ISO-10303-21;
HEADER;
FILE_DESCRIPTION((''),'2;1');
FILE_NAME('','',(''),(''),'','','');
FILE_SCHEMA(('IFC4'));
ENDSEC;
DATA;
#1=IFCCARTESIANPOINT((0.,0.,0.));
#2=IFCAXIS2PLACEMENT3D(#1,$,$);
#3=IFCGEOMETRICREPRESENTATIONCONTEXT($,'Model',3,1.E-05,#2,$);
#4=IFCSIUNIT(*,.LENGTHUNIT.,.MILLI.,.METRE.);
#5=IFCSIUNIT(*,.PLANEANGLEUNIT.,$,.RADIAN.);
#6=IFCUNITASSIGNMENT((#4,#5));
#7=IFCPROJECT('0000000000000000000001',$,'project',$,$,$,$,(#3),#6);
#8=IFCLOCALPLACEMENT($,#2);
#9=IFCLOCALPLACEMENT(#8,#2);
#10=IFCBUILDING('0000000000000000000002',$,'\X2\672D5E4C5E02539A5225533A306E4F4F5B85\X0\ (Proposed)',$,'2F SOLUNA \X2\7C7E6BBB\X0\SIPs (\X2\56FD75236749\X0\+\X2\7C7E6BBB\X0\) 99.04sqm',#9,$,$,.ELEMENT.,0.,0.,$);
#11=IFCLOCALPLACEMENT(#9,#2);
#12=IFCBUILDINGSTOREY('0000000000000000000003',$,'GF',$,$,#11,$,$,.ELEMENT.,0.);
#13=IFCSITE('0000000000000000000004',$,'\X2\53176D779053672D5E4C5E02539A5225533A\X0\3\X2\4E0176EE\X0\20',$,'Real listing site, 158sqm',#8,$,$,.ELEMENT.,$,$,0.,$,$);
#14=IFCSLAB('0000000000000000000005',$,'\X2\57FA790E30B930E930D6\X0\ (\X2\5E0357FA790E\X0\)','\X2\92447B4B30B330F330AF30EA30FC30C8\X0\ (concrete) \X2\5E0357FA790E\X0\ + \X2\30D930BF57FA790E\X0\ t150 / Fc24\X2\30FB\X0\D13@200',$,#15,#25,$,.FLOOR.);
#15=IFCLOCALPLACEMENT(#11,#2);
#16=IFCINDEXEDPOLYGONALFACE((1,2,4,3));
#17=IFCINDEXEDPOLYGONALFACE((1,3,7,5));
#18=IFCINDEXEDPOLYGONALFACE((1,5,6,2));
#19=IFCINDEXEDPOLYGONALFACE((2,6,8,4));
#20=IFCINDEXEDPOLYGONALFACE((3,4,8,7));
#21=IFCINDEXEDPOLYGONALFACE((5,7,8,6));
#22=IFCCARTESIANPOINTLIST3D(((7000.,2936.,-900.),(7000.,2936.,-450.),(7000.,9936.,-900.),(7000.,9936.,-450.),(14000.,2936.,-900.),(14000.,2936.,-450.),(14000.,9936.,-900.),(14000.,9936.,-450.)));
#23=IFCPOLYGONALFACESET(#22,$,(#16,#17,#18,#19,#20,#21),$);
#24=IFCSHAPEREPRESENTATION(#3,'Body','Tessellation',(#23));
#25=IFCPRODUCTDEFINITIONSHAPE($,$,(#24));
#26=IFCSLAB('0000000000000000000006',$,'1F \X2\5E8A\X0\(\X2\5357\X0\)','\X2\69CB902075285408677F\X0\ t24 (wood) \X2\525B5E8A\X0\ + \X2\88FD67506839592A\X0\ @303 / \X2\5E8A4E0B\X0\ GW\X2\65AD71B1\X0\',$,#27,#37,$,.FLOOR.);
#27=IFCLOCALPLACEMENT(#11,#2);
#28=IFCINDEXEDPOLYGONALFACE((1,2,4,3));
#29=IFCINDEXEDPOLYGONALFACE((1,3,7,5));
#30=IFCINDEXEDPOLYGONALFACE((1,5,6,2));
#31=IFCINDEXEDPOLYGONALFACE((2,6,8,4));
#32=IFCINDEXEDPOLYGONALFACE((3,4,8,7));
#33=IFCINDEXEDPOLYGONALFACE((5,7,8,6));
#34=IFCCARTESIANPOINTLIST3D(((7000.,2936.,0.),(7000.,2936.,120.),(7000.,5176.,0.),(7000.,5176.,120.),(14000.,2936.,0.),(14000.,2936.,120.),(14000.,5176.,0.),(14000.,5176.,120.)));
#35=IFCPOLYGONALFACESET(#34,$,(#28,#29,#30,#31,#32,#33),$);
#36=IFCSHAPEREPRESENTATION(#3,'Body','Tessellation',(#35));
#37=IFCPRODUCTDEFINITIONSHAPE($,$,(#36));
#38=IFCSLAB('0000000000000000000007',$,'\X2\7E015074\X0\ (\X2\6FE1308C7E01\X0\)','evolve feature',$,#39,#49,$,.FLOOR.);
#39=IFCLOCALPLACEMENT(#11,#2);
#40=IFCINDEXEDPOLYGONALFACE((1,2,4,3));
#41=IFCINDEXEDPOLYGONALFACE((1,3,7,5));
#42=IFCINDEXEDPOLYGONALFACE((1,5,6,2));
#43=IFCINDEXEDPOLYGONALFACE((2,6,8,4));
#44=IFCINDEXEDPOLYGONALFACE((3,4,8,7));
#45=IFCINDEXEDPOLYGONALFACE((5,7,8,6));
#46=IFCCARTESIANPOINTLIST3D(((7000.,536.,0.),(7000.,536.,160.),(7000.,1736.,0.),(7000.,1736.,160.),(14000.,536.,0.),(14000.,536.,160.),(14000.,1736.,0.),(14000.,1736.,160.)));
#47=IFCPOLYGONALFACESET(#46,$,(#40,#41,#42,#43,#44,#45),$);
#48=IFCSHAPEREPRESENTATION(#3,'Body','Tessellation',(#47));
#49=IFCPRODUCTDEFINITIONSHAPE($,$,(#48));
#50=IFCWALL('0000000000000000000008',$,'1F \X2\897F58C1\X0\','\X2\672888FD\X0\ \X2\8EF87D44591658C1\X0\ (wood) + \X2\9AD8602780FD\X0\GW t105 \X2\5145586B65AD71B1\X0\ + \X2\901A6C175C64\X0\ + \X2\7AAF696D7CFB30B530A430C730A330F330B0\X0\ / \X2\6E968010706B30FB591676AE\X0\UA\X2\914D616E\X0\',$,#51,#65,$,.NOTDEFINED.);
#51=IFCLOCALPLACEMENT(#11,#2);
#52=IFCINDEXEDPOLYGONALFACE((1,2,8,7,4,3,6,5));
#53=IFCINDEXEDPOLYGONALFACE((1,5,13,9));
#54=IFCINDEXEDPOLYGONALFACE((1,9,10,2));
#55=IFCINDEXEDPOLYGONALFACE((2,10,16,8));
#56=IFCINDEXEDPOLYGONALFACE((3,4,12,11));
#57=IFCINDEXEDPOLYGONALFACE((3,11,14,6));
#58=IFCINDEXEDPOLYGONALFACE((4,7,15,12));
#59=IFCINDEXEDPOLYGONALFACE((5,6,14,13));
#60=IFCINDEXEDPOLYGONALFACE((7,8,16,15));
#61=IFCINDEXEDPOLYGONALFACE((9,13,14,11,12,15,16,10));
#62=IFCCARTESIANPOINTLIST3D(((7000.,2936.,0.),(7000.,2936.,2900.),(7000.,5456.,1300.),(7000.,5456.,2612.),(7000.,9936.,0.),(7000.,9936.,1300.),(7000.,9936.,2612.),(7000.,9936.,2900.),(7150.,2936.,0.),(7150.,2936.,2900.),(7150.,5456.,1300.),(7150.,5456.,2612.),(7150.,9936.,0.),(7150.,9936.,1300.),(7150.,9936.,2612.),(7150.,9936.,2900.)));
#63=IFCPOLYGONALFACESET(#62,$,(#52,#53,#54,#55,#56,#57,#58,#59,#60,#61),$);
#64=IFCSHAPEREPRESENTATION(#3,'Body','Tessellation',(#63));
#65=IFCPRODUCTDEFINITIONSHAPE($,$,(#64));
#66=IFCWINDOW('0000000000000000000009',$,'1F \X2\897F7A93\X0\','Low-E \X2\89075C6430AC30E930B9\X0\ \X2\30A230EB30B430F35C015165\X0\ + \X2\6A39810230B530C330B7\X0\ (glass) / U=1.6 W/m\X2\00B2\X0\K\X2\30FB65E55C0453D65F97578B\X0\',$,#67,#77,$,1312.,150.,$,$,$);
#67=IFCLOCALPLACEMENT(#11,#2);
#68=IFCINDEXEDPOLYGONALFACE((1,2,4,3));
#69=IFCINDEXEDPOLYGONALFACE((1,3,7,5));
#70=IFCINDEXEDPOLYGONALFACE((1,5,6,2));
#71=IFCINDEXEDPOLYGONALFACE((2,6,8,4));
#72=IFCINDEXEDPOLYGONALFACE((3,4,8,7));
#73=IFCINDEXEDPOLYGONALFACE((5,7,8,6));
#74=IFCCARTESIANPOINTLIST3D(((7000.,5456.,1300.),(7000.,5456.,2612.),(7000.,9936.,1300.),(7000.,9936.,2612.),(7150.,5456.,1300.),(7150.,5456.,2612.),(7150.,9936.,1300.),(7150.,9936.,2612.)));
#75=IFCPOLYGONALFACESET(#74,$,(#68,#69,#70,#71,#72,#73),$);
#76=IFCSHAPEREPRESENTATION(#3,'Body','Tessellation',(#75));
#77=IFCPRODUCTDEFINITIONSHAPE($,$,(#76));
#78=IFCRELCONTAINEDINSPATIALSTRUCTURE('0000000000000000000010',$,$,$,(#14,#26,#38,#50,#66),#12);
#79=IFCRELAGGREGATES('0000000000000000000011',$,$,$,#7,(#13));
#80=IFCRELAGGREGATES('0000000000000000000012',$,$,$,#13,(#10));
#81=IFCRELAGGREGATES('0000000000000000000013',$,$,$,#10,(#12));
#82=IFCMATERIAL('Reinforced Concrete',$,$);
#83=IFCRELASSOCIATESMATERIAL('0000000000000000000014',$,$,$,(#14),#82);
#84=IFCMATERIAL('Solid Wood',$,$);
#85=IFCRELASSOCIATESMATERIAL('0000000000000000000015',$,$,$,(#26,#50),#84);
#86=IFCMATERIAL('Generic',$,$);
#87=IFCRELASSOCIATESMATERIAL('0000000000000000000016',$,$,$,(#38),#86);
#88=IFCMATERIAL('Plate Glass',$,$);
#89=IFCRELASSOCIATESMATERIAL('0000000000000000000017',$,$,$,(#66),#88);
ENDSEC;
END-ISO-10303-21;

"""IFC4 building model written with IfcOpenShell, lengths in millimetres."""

from ifc_helpers import new_model, si_unit, frame, frame_2d, origin, place, context, project, spatial, rectangle, extrude, material, element, fill, save


model = new_model("IFC4")

# Units and contexts
model_context = context("Model", 3, precision=1e-05, world=origin())
ifc_project = project(units=[si_unit("LENGTHUNIT", "METRE", prefix="MILLI"), si_unit("PLANEANGLEUNIT", "RADIAN")], contexts=[model_context])

# Site, building, storey
site_placement = place(None, origin())
site = spatial("IfcSite", under=ifc_project, at=site_placement, Name="北海道札幌市厚別区3丁目20", ObjectType="Real listing site, 158sqm", CompositionType="ELEMENT", RefElevation=0.0)
building_placement = place(site_placement, origin())
building = spatial("IfcBuilding", under=site, at=building_placement, Name="札幌市厚別区の住宅 (Proposed)", ObjectType="2F SOLUNA 籾殻SIPs (国産杉+籾殻) 99.04sqm", CompositionType="ELEMENT", ElevationOfRefHeight=0.0, ElevationOfTerrain=0.0)
storey_placement = place(building_placement, origin())
storey = spatial("IfcBuildingStorey", under=building, at=storey_placement, Name="GF", CompositionType="ELEMENT", Elevation=0.0)

# Slabs
ifc_material_1 = material(Name="Reinforced Concrete")
slab_1_placement = place(storey_placement, frame((3500.0, 1468.0, -450.0)))
element("IfcSlab", 1, at=slab_1_placement, inside=storey, material=ifc_material_1, Name="基礎スラブ (布基礎)", Description="鉄筋コンクリート (concrete) 布基礎 + ベタ基礎 t150 / Fc24・D13@200", PredefinedType="FLOOR", context=model_context, shape_type="SweptSolid", body=[
    extrude(rectangle(XDim=7000.0, YDim=7000.0, at=frame_2d((3500.0, 3500.0))), frame((3500.0, 1468.0, -450.0)), (0.0, 0.0, 1.0), 450.0),
])
ifc_material_2 = material(Name="Solid Wood")
slab_2_placement = place(storey_placement, frame((3500.0, 1468.0, 0.0)))
element("IfcSlab", 2, at=slab_2_placement, inside=storey, material=ifc_material_2, Name="1F 床(南)", Description="構造用合板 t24 (wood) 剛床 + 製材根太 @303 / 床下 GW断熱", PredefinedType="FLOOR", context=model_context, shape_type="SweptSolid", body=[
    extrude(rectangle(XDim=7000.0, YDim=2240.0, at=frame_2d((3500.0, 1120.0))), frame((3500.0, 1468.0, 0.0)), (0.0, 0.0, 1.0), 120.0),
])
ifc_material_3 = material(Name="Generic")
slab_3_placement = place(storey_placement, frame((3500.0, 268.0, 0.0)))
element("IfcSlab", 3, at=slab_3_placement, inside=storey, material=ifc_material_3, Name="縁側 (濡れ縁)", Description="evolve feature", PredefinedType="FLOOR", context=model_context, shape_type="SweptSolid", body=[
    extrude(rectangle(XDim=7000.0, YDim=1200.0, at=frame_2d((3500.0, 600.0))), frame((3500.0, 268.0, 0.0)), (0.0, 0.0, 1.0), 160.0),
])

# Shared definitions
ifc_material_4 = material(Name="Plate Glass")

# Wall, opening, window
wall_1_placement = place(storey_placement, frame((3500.0, 1468.0, 0.0)))
wall_1 = element("IfcWall", 4, at=wall_1_placement, inside=storey, material=ifc_material_2, Name="1F 西壁", Description="木製 軸組外壁 (wood) + 高性能GW t105 充填断熱 + 通気層 + 窯業系サイディング / 準耐火・外皮UA配慮", PredefinedType="NOTDEFINED", context=model_context, shape_type="SweptSolid", body=[
    extrude(rectangle(XDim=150.0, YDim=7000.0, at=frame_2d((75.0, 3500.0))), frame((3500.0, 1468.0, 0.0)), (0.0, 0.0, 1.0), 2900.0),
])
opening_1_placement = place(storey_placement, frame((3500.0, 2728.0, 650.0)))
opening_1 = element("IfcOpeningElement", 5, at=opening_1_placement, cuts=wall_1, PredefinedType="NOTDEFINED", context=model_context, shape_type="SweptSolid", body=[
    extrude(rectangle(XDim=150.0, YDim=4480.0, at=frame_2d((75.0, 2240.0))), frame((3500.0, 2728.0, 650.0)), (0.0, 0.0, 1.0), 1312.0),
])
window_1_placement = place(storey_placement, frame((3500.0, 2728.0, 650.0)))
window_1 = element("IfcWindow", 6, at=window_1_placement, inside=storey, material=ifc_material_4, Name="1F 西窓", Description="Low-E 複層ガラス アルゴン封入 + 樹脂サッシ (glass) / U=1.6 W/m²K・日射取得型", OverallHeight=1312.0, OverallWidth=150.0, context=model_context, shape_type="SweptSolid", body=[
    extrude(rectangle(XDim=150.0, YDim=4480.0, at=frame_2d((75.0, 2240.0))), frame((3500.0, 2728.0, 650.0)), (0.0, 0.0, 1.0), 1312.0),
])
fill(opening_1, window_1)

save(model, "model.ifc")
